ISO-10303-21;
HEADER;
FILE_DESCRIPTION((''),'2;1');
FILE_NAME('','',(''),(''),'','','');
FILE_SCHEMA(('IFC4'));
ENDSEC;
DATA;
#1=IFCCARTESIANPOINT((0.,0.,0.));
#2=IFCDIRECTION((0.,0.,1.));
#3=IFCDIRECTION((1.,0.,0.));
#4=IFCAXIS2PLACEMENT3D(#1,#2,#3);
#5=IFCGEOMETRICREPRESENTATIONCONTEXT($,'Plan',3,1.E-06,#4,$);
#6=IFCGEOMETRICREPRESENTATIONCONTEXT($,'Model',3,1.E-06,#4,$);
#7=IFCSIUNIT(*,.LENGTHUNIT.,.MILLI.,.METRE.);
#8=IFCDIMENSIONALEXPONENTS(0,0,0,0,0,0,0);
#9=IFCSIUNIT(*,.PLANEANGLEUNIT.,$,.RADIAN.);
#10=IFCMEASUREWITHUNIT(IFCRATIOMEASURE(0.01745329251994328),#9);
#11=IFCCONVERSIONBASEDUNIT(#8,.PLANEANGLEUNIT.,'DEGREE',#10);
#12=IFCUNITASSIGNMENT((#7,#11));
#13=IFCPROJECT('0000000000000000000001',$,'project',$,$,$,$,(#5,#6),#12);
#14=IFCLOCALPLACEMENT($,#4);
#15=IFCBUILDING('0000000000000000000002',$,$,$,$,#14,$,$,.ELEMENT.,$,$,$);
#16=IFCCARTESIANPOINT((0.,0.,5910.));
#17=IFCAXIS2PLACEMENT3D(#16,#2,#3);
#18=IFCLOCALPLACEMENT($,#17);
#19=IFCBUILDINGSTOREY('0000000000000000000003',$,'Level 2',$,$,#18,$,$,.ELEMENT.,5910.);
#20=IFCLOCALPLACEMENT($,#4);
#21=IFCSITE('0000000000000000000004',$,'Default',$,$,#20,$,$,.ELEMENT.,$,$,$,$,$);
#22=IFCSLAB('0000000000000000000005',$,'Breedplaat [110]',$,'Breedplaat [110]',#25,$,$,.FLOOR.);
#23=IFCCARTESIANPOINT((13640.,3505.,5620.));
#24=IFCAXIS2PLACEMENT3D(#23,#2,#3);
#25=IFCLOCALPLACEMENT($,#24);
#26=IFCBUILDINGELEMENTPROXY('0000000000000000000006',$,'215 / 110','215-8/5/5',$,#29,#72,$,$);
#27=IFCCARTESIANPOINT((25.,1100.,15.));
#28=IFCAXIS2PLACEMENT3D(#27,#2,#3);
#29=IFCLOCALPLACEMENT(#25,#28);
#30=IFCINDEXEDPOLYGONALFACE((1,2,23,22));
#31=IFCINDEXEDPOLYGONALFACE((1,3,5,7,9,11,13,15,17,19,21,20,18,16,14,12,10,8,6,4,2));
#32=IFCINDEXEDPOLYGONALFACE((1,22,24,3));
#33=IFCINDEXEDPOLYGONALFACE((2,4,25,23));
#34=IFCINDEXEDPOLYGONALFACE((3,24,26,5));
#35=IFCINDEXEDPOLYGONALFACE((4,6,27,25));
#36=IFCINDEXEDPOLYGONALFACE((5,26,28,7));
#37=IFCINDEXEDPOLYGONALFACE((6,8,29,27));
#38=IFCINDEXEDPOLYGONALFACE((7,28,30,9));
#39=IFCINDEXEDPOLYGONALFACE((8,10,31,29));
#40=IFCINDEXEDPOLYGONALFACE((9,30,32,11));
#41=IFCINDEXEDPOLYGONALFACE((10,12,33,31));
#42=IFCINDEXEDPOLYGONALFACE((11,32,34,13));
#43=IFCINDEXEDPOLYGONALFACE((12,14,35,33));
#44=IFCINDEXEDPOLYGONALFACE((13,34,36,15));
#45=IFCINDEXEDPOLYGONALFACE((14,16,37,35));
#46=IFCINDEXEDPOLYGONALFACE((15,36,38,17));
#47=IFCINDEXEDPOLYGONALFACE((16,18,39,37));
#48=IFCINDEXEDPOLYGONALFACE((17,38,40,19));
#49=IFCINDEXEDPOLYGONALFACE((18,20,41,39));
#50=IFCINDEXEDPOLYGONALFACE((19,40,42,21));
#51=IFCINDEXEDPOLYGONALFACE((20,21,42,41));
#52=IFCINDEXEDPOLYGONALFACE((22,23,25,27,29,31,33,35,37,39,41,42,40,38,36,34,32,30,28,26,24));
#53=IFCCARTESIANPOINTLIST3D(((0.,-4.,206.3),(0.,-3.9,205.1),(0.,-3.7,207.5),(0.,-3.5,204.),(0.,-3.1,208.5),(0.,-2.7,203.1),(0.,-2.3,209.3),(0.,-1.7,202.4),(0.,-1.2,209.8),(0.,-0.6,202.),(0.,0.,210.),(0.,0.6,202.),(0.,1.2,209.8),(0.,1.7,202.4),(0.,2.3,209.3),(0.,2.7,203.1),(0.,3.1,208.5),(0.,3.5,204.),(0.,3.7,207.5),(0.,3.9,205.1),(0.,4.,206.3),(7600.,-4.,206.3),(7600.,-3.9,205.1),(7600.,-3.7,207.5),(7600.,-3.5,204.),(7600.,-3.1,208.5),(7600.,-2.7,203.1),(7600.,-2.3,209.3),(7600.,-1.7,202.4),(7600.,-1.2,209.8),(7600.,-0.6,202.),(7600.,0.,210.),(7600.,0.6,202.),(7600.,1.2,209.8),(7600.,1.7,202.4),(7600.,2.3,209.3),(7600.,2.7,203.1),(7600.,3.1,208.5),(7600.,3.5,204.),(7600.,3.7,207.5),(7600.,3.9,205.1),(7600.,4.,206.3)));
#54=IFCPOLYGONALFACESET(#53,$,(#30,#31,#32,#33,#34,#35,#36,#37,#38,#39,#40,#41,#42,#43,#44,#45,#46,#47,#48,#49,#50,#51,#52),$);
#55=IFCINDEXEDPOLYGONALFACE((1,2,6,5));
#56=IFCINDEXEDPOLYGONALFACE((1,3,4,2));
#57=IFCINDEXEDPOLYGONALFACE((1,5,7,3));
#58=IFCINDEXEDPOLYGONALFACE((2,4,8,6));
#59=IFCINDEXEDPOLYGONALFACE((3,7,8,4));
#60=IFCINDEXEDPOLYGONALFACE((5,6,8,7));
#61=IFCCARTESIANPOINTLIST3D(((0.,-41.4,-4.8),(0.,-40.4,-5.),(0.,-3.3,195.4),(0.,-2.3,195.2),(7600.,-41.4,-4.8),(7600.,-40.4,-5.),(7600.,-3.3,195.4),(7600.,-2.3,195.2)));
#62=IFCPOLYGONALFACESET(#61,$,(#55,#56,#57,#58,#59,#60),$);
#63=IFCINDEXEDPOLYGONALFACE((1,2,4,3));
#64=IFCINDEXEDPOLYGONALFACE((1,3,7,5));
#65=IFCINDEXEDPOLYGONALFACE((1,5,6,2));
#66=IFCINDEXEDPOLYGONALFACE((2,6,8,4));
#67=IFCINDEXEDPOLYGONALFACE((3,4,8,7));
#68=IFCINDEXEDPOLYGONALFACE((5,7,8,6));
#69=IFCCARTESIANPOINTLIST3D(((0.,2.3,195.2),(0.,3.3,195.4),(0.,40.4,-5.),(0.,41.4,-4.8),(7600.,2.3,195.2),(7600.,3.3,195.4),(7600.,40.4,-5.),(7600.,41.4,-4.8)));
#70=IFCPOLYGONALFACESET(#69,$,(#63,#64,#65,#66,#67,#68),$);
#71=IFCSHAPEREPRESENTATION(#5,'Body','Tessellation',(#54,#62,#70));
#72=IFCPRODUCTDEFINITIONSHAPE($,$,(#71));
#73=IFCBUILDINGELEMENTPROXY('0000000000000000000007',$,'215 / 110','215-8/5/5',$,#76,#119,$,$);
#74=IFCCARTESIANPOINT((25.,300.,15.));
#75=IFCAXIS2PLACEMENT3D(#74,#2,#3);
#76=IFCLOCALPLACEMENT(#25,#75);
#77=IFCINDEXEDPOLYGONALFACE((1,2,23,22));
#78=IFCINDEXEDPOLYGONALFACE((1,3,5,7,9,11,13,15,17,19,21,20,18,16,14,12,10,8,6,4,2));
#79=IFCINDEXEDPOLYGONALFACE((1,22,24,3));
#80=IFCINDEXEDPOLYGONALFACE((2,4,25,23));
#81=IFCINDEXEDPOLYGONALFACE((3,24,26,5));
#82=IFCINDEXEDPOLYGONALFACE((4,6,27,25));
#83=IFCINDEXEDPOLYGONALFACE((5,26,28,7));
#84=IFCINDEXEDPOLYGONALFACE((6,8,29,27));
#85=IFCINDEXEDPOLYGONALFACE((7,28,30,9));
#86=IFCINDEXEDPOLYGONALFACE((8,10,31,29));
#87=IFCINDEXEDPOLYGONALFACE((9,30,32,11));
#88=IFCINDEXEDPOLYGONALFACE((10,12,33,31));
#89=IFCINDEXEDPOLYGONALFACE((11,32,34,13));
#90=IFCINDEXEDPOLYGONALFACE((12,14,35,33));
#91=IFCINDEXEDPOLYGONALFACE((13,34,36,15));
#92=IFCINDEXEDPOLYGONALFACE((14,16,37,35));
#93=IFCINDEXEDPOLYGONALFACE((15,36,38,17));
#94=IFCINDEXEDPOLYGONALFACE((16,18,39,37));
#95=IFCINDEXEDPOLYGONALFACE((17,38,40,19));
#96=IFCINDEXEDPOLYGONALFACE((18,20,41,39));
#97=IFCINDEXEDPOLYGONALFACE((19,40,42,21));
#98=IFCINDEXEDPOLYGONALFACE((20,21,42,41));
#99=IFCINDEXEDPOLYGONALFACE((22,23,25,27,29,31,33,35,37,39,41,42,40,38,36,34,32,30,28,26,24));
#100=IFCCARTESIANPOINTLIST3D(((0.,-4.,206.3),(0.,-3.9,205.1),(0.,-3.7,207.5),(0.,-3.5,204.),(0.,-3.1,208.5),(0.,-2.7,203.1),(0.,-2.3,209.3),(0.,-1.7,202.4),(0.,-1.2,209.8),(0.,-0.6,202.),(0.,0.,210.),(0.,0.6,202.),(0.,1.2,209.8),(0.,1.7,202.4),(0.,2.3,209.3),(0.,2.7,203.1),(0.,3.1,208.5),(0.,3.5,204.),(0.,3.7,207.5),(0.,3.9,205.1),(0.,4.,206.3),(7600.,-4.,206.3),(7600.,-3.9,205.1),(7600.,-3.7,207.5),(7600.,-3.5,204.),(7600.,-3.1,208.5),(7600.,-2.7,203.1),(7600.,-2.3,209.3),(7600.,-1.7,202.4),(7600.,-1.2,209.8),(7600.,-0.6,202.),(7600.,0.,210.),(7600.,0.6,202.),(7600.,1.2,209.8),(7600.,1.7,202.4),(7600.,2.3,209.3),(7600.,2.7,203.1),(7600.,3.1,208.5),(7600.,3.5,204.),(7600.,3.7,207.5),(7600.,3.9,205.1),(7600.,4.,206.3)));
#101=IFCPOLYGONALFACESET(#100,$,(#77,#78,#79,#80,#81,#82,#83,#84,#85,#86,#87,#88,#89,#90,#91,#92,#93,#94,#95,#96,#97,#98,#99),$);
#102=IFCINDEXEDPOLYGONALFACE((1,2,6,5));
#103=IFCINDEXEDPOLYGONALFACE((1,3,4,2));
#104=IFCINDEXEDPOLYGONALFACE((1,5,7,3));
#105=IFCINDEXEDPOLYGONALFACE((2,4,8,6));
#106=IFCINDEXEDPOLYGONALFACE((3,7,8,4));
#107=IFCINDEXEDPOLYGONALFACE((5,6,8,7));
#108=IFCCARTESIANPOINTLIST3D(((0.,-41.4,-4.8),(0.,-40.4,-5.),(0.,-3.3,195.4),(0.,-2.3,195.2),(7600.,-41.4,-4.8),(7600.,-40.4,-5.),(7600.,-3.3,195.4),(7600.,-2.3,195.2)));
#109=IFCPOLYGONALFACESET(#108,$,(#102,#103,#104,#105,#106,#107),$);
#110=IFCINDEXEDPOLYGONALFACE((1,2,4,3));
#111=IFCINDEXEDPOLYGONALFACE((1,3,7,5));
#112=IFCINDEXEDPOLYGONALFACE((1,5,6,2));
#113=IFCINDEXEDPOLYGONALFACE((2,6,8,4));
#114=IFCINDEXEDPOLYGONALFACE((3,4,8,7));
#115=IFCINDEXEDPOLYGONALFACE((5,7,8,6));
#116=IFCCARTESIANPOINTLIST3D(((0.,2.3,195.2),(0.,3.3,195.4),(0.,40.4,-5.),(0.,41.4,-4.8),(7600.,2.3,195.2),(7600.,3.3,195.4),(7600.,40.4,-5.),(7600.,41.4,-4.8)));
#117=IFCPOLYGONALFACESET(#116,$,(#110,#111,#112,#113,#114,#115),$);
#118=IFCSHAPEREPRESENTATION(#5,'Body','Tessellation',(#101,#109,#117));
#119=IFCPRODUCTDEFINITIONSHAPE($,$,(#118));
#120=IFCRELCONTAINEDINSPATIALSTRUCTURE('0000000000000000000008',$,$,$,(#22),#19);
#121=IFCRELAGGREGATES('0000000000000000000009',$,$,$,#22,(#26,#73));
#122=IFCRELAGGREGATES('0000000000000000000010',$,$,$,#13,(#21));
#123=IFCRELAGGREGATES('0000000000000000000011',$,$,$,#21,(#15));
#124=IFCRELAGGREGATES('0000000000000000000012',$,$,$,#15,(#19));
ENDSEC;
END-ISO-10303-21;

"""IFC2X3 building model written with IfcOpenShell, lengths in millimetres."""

from ifc_helpers import new_model, entity, si_unit, converted_unit, frame, origin_with_axes, origin_2d_with_axis, place, context, project, spatial, rectangle, circle, extrude, element, aggregate, save


model = new_model("IFC2X3")

# Units and contexts
plan_context = context("Plan", 3, precision=1e-06, world=origin_with_axes())
model_context = context("Model", 3, precision=1e-06, world=origin_with_axes())
ifc_project = project(units=[si_unit("LENGTHUNIT", "METRE", prefix="MILLI"), converted_unit("PLANEANGLEUNIT", "DEGREE", entity("IfcRatioMeasure", 0.01745329251994328), si_unit("PLANEANGLEUNIT", "RADIAN"), dimensions=[0, 0, 0, 0, 0, 0, 0])], contexts=[plan_context, model_context])

# Site, building, storey
site_placement = place(None, origin_with_axes())
site = spatial("IfcSite", under=ifc_project, at=site_placement, Name="Default", CompositionType="ELEMENT")
building_placement = place(None, origin_with_axes())
building = spatial("IfcBuilding", under=site, at=building_placement, CompositionType="ELEMENT")
storey_placement = place(None, frame((0.0, 0.0, 5910.0), z_axis=(0.0, 0.0, 1.0), x_axis=(1.0, 0.0, 0.0)))
storey = spatial("IfcBuildingStorey", under=building, at=storey_placement, Name="Level 2", CompositionType="ELEMENT", Elevation=5910.0)

# Slab, building element proxies
slab_1_placement = place(None, frame((13640.0, 3505.0, 5620.0), z_axis=(0.0, 0.0, 1.0), x_axis=(1.0, 0.0, 0.0)))
slab_1 = element("IfcSlab", 1, at=slab_1_placement, inside=storey, Name="Breedplaat [110]", ObjectType="Breedplaat [110]", PredefinedType="FLOOR")
proxy_1_placement = place(slab_1_placement, frame((25.0, 1100.0, 15.0), z_axis=(0.0, 0.0, 1.0), x_axis=(1.0, 0.0, 0.0)))
proxy_1 = element("IfcBuildingElementProxy", 2, at=proxy_1_placement, Name="215 / 110", Description="215-8/5/5", context=plan_context, shape_type="SweptSolid", body=[
    extrude(circle(Radius=4.0, at=origin_2d_with_axis()), frame((0.0, 0.0, 206.0), z_axis=(1.0, 0.0, 0.0), x_axis=(0.0, 0.0, 1.0)), (0.0, 0.0, 1.0), 7600.0),
    extrude(rectangle(XDim=203.8, YDim=1.0, at=origin_2d_with_axis()), frame((0.0, -21.9, 95.2), z_axis=(1.0, 0.0, 0.0), x_axis=(0.0, 0.187112, 0.982339)), (0.0, 0.0, 1.0), 7600.0),
    extrude(rectangle(XDim=203.8, YDim=1.0, at=origin_2d_with_axis()), frame((0.0, 21.9, 95.2), z_axis=(1.0, 0.0, 0.0), x_axis=(0.0, -0.187112, 0.982339)), (0.0, 0.0, 1.0), 7600.0),
])
proxy_2_placement = place(slab_1_placement, frame((25.0, 300.0, 15.0), z_axis=(0.0, 0.0, 1.0), x_axis=(1.0, 0.0, 0.0)))
proxy_2 = element("IfcBuildingElementProxy", 3, at=proxy_2_placement, Name="215 / 110", Description="215-8/5/5", context=plan_context, shape_type="SweptSolid", body=[
    extrude(circle(Radius=4.0, at=origin_2d_with_axis()), frame((0.0, 0.0, 206.0), z_axis=(1.0, 0.0, 0.0), x_axis=(0.0, 0.0, 1.0)), (0.0, 0.0, 1.0), 7600.0),
    extrude(rectangle(XDim=203.8, YDim=1.0, at=origin_2d_with_axis()), frame((0.0, -21.9, 95.2), z_axis=(1.0, 0.0, 0.0), x_axis=(0.0, 0.187112, 0.982339)), (0.0, 0.0, 1.0), 7600.0),
    extrude(rectangle(XDim=203.8, YDim=1.0, at=origin_2d_with_axis()), frame((0.0, 21.9, 95.2), z_axis=(1.0, 0.0, 0.0), x_axis=(0.0, -0.187112, 0.982339)), (0.0, 0.0, 1.0), 7600.0),
])
aggregate(slab_1, [proxy_1, proxy_2])

save(model, "model.ifc")
